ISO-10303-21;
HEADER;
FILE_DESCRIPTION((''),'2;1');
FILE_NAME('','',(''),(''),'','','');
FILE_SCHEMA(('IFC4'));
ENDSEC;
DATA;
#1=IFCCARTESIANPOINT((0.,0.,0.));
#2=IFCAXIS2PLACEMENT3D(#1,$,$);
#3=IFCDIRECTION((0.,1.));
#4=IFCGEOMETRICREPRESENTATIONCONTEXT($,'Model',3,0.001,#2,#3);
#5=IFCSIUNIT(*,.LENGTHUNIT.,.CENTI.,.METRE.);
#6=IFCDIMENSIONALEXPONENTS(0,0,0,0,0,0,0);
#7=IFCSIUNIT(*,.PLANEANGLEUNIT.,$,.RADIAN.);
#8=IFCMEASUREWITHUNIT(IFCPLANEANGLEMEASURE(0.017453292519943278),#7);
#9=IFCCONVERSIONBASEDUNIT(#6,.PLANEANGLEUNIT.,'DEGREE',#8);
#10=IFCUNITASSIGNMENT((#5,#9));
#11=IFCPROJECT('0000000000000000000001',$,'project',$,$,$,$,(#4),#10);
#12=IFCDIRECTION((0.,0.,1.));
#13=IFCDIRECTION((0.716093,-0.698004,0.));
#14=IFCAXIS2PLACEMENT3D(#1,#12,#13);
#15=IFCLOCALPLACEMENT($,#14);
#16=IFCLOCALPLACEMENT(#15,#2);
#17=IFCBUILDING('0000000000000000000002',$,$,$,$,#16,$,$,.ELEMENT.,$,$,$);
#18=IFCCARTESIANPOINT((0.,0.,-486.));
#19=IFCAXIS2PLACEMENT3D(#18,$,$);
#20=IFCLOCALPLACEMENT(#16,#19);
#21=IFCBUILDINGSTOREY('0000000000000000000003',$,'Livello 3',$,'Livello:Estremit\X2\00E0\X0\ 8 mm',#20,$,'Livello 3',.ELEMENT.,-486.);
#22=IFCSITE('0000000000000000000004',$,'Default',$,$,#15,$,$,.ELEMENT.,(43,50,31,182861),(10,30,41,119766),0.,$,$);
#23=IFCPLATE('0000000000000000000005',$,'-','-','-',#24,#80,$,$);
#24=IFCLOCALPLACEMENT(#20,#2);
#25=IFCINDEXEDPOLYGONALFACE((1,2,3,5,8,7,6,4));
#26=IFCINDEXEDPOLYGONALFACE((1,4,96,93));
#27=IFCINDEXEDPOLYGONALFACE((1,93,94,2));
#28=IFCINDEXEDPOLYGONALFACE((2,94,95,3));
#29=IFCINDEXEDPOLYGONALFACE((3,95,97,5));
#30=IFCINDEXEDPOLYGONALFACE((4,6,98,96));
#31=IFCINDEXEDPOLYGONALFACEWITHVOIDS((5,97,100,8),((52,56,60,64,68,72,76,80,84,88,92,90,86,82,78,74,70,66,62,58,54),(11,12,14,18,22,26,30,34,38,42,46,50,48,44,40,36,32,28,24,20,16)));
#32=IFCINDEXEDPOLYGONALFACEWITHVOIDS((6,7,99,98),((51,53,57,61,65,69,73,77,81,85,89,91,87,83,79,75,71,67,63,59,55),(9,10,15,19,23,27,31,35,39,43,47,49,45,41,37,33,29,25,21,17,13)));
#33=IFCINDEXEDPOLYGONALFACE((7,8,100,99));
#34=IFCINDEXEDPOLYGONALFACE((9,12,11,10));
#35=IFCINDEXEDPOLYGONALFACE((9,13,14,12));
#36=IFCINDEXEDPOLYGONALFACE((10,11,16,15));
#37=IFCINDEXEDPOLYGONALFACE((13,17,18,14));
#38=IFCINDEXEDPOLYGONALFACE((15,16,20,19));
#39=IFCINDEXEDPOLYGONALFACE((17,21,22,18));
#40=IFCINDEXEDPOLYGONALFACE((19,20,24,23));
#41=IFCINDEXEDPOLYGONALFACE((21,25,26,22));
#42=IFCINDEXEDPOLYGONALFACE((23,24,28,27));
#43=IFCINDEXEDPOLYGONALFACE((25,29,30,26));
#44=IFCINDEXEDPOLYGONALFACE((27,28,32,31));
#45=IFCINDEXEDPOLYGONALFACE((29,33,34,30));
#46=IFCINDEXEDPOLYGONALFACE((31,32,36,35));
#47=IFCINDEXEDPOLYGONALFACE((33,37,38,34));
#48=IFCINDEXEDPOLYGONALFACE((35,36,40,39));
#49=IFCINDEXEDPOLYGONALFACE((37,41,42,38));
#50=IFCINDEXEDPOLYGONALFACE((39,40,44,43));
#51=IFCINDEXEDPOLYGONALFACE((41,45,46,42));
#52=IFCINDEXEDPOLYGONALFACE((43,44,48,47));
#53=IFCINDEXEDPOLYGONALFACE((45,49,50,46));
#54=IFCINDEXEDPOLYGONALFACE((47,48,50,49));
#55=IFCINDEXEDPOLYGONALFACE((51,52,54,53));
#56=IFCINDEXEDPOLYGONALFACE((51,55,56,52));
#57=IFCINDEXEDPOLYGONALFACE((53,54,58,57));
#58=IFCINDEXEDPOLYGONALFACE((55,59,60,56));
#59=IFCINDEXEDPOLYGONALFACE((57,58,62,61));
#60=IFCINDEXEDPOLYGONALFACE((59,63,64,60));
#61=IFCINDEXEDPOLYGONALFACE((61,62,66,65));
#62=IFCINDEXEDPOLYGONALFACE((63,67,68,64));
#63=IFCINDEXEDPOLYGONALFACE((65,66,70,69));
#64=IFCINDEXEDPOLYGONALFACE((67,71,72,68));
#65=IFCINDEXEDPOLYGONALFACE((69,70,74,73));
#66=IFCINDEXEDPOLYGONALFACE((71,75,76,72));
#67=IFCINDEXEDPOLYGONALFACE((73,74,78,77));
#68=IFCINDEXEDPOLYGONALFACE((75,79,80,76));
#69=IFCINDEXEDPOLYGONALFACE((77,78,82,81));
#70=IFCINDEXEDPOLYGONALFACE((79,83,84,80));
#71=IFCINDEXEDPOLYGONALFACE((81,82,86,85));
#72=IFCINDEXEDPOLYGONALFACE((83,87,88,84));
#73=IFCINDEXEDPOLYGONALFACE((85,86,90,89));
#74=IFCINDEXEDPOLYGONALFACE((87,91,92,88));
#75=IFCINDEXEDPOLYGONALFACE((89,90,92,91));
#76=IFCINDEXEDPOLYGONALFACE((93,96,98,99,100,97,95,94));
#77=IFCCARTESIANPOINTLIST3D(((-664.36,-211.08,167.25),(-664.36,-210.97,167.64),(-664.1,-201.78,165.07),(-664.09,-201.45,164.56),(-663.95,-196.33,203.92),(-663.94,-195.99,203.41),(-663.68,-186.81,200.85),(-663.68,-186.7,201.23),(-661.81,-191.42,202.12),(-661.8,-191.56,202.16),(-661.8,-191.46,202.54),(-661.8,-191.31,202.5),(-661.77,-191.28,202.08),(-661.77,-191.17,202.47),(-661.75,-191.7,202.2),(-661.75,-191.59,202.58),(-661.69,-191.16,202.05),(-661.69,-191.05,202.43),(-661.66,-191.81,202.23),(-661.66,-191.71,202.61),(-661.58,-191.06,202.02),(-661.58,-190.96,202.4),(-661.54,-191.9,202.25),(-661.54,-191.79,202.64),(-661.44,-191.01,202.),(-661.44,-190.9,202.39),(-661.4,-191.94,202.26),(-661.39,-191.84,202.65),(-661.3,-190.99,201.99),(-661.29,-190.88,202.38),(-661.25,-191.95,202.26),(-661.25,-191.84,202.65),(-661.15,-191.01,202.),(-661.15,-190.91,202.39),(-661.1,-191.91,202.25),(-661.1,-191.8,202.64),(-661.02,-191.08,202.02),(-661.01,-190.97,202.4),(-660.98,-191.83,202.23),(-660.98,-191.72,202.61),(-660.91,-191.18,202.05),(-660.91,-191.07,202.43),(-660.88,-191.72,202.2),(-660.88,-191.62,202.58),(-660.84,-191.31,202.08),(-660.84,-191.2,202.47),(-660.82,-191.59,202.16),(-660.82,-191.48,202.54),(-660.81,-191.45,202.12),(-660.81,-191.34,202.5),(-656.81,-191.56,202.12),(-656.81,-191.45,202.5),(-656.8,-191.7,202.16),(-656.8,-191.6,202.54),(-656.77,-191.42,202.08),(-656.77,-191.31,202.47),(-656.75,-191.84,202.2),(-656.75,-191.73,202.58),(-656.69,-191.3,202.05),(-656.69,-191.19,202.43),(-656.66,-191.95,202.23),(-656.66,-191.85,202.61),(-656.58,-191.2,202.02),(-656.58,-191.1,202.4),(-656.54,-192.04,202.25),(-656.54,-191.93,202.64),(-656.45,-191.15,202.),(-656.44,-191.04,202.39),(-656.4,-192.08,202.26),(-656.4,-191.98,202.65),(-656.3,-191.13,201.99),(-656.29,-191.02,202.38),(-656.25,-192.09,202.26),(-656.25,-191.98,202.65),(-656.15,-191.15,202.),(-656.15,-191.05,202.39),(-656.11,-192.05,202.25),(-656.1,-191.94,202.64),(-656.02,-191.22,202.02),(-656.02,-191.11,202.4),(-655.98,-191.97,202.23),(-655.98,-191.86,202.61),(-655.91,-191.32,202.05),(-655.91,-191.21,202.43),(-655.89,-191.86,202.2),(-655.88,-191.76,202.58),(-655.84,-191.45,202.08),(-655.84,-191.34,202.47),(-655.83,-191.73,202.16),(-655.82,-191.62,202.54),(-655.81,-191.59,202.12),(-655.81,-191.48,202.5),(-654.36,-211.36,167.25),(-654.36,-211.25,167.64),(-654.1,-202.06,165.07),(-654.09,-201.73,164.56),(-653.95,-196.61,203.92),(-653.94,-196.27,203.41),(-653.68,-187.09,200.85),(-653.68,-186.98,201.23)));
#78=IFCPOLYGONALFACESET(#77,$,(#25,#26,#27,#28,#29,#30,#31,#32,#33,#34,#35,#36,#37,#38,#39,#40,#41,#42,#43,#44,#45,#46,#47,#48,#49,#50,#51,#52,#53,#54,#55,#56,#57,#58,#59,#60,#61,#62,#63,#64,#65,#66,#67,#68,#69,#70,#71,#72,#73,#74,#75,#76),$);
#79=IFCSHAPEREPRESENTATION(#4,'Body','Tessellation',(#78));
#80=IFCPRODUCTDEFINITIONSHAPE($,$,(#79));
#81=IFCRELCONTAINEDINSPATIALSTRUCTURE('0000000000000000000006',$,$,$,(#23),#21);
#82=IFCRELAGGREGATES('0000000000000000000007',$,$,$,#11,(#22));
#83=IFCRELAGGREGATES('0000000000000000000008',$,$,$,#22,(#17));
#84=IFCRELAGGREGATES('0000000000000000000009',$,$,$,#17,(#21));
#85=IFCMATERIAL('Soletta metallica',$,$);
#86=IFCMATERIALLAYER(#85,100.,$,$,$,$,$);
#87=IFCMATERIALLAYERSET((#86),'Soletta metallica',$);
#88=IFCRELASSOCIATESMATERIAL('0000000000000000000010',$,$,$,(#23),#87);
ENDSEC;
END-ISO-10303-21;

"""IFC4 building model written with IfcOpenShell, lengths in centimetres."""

from ifc_helpers import new_model, entity, si_unit, converted_unit, direction, frame, frame_2d, origin, origin_with_axes, place, context, project, spatial, polyline, circle, outline, extrude, material, layer, layer_set, element, save


model = new_model("IFC4")

# Units and contexts
model_context = context("Model", 3, precision=0.001, world=origin(), true_north=direction((0.0, 1.0)))
ifc_project = project(units=[si_unit("LENGTHUNIT", "METRE", prefix="CENTI"), converted_unit("PLANEANGLEUNIT", "DEGREE", entity("IfcPlaneAngleMeasure", 0.017453292519943278), si_unit("PLANEANGLEUNIT", "RADIAN"), dimensions=[0, 0, 0, 0, 0, 0, 0])], contexts=[model_context])

# Site, building, storey
site_placement = place(None, frame((0.0, 0.0, 0.0), z_axis=(0.0, 0.0, 1.0), x_axis=(0.716093, -0.698004, 0.0)))
site = spatial("IfcSite", under=ifc_project, at=site_placement, Name="Default", CompositionType="ELEMENT", RefLatitude=(43, 50, 31, 182861), RefLongitude=(10, 30, 41, 119766), RefElevation=0.0)
building_placement = place(site_placement, origin())
building = spatial("IfcBuilding", under=site, at=building_placement, CompositionType="ELEMENT")
storey_placement = place(building_placement, frame((0.0, 0.0, -486.0)))
storey = spatial("IfcBuildingStorey", under=building, at=storey_placement, Name="Livello 3", ObjectType="Livello:Estremità 8 mm", LongName="Livello 3", CompositionType="ELEMENT", Elevation=-486.0)

# Plate, openings
ifc_material_1 = material(Name="Soletta metallica")
ifc_layer_1 = layer(ifc_material_1, 100.0)
ifc_layer_set_1 = layer_set([ifc_layer_1], Name="Soletta metallica")
plate_1_placement = place(storey_placement, frame((-653.64, -185.55, 200.87), z_axis=(-0.999608, 0.02798, 0.0), x_axis=(-0.02798, -0.999608, 0.0)))
plate_1 = element("IfcPlate", 1, at=plate_1_placement, inside=storey, material=ifc_layer_set_1, Name="-", Description="-", ObjectType="-", context=model_context, shape_type="SweptSolid", body=[
    extrude(outline(polyline([(1.54, -0.03), (10.73, 2.54), (16.19, -36.31), (25.82, -33.62), (25.71, -33.24), (16.52, -35.8), (11.06, 3.05), (1.43, 0.36), (1.54, -0.03)])), origin_with_axes(), (0.0, 0.0, 1.0), 10.0),
])
opening_1_placement = place(plate_1_placement, frame((5.78, 2.51, 3.0), z_axis=(-0.268612, 0.963248, 0.0), x_axis=(-0.963248, -0.268612, 0.0)))
element("IfcOpeningElement", 2, at=opening_1_placement, cuts=plate_1, ObjectType="Opening", context=model_context, shape_type="SweptSolid", body=[
    extrude(circle(Radius=0.5, at=frame_2d((0.0, -0.5), x_axis=(1.0, 0.0))), origin(), (0.0, 0.0, -1.0), 1.35),
])
opening_2_placement = place(plate_1_placement, frame((5.78, 2.51, 8.0), z_axis=(-0.268612, 0.963248, 0.0), x_axis=(-0.963248, -0.268612, 0.0)))
element("IfcOpeningElement", 3, at=opening_2_placement, cuts=plate_1, ObjectType="Opening", context=model_context, shape_type="SweptSolid", body=[
    extrude(circle(Radius=0.5, at=frame_2d((0.0, -0.5), x_axis=(1.0, 0.0))), origin(), (0.0, 0.0, -1.0), 1.35),
])

save(model, "model.ifc")
